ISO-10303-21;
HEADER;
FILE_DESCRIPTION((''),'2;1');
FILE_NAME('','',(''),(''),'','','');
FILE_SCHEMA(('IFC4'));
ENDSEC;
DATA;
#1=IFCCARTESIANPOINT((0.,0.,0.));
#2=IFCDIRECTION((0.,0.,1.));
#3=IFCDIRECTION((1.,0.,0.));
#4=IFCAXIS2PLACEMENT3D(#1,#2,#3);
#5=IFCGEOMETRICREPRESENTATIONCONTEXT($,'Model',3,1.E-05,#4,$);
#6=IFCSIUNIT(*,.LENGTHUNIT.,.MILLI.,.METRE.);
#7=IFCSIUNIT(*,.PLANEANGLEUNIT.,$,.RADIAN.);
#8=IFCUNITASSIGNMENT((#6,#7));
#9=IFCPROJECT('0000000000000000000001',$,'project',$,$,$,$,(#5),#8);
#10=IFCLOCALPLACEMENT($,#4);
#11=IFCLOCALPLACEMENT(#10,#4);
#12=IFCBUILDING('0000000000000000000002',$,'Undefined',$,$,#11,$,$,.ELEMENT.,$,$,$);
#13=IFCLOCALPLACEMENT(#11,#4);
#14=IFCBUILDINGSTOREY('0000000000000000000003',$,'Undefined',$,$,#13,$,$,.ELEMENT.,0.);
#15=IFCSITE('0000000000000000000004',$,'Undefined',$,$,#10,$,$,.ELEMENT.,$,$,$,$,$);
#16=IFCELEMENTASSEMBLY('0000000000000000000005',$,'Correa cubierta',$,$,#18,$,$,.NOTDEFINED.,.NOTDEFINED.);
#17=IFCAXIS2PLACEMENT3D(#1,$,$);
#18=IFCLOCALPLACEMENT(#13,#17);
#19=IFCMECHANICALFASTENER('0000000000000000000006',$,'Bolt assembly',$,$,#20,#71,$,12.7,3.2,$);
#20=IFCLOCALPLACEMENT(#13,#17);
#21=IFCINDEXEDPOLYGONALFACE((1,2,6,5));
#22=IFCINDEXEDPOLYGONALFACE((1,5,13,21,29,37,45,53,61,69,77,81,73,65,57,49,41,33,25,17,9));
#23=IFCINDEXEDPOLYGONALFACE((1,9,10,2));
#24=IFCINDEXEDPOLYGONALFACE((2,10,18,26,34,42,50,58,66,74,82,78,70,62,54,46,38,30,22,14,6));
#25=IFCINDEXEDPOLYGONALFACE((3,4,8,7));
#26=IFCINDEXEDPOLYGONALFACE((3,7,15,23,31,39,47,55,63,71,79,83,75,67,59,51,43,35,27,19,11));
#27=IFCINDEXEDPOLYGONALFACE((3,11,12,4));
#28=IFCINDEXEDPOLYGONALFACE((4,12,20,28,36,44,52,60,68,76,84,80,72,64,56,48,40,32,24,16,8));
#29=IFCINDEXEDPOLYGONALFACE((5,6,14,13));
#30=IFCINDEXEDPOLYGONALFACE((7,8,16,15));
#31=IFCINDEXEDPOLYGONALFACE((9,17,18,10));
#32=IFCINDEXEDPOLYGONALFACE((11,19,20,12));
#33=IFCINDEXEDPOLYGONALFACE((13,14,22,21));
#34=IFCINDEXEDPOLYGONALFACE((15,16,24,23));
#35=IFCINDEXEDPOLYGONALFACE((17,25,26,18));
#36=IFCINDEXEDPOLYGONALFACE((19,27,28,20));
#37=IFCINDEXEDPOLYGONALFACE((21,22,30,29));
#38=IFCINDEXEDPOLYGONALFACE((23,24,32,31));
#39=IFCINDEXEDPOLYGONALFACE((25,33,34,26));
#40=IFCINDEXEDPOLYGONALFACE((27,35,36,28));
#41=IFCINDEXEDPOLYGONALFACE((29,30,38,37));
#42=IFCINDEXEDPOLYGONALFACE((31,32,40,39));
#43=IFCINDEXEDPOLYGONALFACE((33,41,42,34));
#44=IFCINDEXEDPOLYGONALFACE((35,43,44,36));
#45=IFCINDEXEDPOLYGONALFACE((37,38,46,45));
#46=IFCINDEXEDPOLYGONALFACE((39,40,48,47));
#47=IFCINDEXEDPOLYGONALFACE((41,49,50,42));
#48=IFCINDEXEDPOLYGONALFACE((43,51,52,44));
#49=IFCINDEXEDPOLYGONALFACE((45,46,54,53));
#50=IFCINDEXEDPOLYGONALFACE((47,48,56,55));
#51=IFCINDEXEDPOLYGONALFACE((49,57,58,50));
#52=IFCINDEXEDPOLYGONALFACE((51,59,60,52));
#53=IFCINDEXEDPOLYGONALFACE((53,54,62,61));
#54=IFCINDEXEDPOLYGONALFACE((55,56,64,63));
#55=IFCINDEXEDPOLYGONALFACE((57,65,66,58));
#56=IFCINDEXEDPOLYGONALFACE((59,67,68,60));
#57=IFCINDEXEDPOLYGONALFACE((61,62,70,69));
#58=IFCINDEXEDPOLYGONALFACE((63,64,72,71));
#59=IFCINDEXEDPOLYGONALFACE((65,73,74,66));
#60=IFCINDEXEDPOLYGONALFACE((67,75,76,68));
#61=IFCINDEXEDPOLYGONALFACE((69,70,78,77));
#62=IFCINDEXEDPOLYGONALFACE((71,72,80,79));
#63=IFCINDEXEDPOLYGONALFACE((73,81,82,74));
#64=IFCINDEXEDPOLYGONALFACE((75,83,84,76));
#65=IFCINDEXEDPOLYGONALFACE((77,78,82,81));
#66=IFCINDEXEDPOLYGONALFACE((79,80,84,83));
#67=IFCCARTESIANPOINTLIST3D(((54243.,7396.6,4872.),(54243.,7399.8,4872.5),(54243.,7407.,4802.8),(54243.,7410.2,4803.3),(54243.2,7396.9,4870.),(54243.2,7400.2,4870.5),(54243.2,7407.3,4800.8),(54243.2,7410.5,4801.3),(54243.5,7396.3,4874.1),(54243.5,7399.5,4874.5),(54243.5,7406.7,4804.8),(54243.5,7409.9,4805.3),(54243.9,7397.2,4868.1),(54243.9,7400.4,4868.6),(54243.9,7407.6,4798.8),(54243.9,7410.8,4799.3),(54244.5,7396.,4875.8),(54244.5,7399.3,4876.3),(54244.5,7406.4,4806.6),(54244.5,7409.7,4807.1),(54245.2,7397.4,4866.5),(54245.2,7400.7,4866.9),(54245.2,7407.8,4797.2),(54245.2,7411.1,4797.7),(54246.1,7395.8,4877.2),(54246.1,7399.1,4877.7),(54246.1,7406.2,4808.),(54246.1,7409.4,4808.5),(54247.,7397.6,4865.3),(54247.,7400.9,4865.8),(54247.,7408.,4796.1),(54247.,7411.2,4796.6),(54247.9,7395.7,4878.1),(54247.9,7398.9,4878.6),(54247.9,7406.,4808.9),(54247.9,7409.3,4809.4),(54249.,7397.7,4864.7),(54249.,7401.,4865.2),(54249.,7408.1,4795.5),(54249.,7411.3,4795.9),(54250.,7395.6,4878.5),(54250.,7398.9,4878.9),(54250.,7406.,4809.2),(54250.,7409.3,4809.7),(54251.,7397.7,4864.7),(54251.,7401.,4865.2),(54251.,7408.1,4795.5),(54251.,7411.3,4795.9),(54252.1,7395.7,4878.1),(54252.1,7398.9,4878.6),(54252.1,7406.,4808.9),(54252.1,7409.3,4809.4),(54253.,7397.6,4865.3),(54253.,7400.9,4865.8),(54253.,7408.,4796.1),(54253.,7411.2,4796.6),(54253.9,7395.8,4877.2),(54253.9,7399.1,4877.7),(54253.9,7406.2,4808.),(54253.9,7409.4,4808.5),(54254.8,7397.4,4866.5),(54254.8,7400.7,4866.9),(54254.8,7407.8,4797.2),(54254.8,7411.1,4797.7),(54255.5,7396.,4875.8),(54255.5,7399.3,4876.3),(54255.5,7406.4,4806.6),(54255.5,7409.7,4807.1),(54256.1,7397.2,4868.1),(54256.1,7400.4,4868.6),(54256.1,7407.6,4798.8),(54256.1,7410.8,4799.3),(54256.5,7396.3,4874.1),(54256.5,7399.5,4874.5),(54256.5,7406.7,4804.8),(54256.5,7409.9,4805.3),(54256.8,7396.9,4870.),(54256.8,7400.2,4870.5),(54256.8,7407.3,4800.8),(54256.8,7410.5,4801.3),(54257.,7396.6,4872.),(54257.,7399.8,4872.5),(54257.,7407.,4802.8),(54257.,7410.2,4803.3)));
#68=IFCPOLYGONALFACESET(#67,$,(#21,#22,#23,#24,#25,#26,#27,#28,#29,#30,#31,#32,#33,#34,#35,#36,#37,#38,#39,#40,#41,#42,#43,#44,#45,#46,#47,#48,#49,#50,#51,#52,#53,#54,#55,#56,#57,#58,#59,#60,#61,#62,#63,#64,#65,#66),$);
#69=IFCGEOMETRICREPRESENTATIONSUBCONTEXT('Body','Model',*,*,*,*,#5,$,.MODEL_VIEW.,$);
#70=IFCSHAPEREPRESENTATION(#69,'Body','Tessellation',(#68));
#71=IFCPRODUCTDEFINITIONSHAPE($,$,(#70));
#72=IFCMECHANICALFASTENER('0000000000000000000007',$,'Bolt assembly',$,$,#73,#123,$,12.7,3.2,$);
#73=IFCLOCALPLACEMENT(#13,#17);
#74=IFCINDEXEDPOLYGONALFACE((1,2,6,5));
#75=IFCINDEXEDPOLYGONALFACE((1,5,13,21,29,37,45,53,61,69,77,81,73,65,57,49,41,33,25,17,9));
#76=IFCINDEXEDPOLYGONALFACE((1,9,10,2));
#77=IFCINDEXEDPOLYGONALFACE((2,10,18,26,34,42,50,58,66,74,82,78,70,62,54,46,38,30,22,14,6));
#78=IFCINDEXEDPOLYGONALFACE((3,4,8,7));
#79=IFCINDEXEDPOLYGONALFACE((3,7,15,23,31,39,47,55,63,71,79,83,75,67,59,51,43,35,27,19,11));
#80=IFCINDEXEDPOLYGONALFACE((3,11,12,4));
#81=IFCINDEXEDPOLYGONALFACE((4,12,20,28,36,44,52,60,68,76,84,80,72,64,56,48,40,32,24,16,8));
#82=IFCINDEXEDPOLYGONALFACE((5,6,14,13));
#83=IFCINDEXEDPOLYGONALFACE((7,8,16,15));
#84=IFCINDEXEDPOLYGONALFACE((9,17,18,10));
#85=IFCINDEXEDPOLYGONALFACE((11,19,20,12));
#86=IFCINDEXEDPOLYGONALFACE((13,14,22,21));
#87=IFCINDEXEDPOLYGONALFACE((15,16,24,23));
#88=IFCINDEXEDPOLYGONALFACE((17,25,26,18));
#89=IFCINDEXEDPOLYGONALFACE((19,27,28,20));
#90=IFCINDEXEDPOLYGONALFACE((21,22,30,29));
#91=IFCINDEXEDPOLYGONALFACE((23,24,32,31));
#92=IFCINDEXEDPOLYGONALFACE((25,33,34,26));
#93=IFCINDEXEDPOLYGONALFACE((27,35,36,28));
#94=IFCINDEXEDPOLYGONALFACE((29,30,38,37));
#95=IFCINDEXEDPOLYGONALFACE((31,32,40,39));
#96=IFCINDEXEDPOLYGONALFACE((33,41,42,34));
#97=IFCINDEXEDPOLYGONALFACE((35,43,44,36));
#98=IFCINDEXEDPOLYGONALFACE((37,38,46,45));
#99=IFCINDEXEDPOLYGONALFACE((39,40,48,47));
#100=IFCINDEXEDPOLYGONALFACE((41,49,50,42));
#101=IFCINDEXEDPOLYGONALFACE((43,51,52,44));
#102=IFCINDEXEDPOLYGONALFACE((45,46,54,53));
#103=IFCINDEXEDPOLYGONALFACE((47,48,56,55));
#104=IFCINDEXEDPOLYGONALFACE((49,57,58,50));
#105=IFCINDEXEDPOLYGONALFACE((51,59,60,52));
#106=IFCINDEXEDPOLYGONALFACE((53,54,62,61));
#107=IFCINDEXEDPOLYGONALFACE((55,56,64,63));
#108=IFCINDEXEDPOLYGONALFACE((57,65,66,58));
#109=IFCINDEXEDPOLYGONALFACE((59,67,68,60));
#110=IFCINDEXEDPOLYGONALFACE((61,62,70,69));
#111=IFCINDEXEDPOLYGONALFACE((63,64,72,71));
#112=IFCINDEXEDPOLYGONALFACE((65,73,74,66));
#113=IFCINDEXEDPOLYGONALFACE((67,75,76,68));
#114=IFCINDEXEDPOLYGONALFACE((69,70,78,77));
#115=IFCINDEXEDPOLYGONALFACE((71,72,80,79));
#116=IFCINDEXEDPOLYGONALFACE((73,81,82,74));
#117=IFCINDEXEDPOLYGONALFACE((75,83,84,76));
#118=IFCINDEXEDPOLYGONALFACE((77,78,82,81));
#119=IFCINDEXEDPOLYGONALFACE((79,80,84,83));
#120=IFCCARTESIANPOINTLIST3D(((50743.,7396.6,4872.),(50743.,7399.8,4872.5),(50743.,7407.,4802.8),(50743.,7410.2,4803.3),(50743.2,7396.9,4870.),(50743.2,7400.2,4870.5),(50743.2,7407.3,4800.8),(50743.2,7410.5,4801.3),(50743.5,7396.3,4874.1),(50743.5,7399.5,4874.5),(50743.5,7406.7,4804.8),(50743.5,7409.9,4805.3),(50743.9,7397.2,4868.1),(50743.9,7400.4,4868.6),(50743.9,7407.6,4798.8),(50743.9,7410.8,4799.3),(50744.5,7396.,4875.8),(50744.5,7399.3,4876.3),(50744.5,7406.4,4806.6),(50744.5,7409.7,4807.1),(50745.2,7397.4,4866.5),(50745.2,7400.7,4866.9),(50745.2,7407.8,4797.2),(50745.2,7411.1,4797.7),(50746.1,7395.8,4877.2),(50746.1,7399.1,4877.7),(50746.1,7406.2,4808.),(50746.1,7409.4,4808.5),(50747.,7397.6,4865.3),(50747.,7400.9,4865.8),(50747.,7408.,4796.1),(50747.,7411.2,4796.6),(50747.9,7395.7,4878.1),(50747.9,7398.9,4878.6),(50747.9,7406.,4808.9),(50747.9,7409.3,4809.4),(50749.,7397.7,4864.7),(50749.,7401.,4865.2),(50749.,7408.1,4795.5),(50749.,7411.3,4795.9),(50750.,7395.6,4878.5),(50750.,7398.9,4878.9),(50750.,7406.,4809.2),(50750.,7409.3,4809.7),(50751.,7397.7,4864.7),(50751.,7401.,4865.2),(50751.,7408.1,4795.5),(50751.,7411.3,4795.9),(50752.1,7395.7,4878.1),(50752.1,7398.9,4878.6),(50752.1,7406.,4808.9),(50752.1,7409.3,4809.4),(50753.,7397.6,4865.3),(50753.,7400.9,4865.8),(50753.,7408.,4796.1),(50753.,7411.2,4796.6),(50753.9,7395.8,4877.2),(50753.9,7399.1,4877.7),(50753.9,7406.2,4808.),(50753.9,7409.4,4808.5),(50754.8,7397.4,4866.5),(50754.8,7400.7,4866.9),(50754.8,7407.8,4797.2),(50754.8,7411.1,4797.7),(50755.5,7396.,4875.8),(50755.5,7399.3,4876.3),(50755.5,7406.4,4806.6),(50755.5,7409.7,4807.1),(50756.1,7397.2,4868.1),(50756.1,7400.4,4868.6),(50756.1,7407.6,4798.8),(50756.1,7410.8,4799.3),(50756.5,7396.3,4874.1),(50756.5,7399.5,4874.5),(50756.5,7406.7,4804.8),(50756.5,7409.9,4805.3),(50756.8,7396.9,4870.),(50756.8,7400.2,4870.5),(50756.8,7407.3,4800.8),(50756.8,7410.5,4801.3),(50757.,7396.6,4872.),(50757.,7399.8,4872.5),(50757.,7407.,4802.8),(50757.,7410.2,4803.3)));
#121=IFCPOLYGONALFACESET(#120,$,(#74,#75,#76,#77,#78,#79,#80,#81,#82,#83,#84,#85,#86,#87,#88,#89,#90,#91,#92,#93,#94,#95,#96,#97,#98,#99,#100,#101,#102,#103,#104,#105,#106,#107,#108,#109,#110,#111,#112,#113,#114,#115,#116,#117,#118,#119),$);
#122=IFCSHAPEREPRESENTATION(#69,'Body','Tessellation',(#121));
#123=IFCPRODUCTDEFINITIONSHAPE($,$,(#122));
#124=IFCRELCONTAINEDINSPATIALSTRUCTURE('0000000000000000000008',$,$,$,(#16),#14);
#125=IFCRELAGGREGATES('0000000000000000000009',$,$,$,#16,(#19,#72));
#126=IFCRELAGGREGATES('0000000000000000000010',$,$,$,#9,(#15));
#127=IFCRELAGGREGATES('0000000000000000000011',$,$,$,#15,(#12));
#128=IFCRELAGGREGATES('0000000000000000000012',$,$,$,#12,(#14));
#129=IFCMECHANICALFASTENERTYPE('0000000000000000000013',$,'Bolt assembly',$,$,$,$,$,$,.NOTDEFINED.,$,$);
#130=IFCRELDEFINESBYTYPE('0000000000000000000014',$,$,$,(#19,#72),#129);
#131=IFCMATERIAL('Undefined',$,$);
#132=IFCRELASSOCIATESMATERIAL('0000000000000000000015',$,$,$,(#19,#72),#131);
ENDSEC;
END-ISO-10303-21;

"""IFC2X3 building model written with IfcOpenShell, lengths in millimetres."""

from ifc_helpers import new_model, si_unit, frame, origin_with_axes, origin_2d_with_axis, place, context, subcontext, project, spatial, circle, extrude, source, transform, mapped, material, type_object, element, aggregate, save


model = new_model("IFC2X3")

# Units and contexts
model_context = context("Model", 3, precision=1e-05, world=origin_with_axes())
body_context = subcontext(model_context, "Body", "Model", "MODEL_VIEW")
ifc_project = project(units=[si_unit("LENGTHUNIT", "METRE", prefix="MILLI"), si_unit("PLANEANGLEUNIT", "RADIAN")], contexts=[model_context])

# Site, building, storey
site_placement = place(None, origin_with_axes())
site = spatial("IfcSite", under=ifc_project, at=site_placement, Name="Undefined", CompositionType="ELEMENT")
building_placement = place(site_placement, origin_with_axes())
building = spatial("IfcBuilding", under=site, at=building_placement, Name="Undefined", CompositionType="ELEMENT")
storey_placement = place(building_placement, origin_with_axes())
storey = spatial("IfcBuildingStorey", under=building, at=storey_placement, Name="Undefined", CompositionType="ELEMENT", Elevation=0.0)

# Shared definitions
ifc_material_1 = material(Name="Undefined")
mechanical_fastener_type = type_object("IfcMechanicalFastenerType", Name="Bolt assembly")

# Element assembly, mechanical fasteners
shared_shape_1 = source(origin_with_axes(), body_context, "Body", "SweptSolid", [
    extrude(circle(Radius=7.0, at=origin_2d_with_axis()), frame((0.0, 3.2, 0.0), z_axis=(0.0, 1.0, 0.0), x_axis=(1.0, 0.0, 0.0)), (0.0, 0.0, 1.0), 3.3),
])
assembly_1_placement = place(storey_placement, origin_with_axes())
assembly_1 = element("IfcElementAssembly", 1, at=assembly_1_placement, inside=storey, Name="Correa cubierta", AssemblyPlace="NOTDEFINED", PredefinedType="NOTDEFINED")
mechanical_fastener_1_placement = place(assembly_1_placement, frame((54250.0, 7413.5, 4803.3), z_axis=(1.0, 0.0, 0.0), x_axis=(0.0, -0.148209, 0.988956)))
mechanical_fastener_1 = element("IfcMechanicalFastener", 2, at=mechanical_fastener_1_placement, type_object=mechanical_fastener_type, material=ifc_material_1, Name="Bolt assembly", NominalDiameter=12.7, NominalLength=3.2, context=body_context, shape_type="MappedRepresentation", body=[
    mapped(shared_shape_1, transform((0.0, 0.0, 0.0))),
    mapped(shared_shape_1, transform((70.0, 0.0, 0.0))),
])
mechanical_fastener_2_placement = place(assembly_1_placement, frame((50750.0, 7413.5, 4803.3), z_axis=(1.0, 0.0, 0.0), x_axis=(0.0, -0.148209, 0.988956)))
mechanical_fastener_2 = element("IfcMechanicalFastener", 3, at=mechanical_fastener_2_placement, type_object=mechanical_fastener_type, material=ifc_material_1, Name="Bolt assembly", NominalDiameter=12.7, NominalLength=3.2, context=body_context, shape_type="MappedRepresentation", body=[
    mapped(shared_shape_1, transform((0.0, 0.0, 0.0))),
    mapped(shared_shape_1, transform((70.0, 0.0, 0.0))),
])

aggregate(assembly_1, [mechanical_fastener_1, mechanical_fastener_2])

save(model, "model.ifc")
